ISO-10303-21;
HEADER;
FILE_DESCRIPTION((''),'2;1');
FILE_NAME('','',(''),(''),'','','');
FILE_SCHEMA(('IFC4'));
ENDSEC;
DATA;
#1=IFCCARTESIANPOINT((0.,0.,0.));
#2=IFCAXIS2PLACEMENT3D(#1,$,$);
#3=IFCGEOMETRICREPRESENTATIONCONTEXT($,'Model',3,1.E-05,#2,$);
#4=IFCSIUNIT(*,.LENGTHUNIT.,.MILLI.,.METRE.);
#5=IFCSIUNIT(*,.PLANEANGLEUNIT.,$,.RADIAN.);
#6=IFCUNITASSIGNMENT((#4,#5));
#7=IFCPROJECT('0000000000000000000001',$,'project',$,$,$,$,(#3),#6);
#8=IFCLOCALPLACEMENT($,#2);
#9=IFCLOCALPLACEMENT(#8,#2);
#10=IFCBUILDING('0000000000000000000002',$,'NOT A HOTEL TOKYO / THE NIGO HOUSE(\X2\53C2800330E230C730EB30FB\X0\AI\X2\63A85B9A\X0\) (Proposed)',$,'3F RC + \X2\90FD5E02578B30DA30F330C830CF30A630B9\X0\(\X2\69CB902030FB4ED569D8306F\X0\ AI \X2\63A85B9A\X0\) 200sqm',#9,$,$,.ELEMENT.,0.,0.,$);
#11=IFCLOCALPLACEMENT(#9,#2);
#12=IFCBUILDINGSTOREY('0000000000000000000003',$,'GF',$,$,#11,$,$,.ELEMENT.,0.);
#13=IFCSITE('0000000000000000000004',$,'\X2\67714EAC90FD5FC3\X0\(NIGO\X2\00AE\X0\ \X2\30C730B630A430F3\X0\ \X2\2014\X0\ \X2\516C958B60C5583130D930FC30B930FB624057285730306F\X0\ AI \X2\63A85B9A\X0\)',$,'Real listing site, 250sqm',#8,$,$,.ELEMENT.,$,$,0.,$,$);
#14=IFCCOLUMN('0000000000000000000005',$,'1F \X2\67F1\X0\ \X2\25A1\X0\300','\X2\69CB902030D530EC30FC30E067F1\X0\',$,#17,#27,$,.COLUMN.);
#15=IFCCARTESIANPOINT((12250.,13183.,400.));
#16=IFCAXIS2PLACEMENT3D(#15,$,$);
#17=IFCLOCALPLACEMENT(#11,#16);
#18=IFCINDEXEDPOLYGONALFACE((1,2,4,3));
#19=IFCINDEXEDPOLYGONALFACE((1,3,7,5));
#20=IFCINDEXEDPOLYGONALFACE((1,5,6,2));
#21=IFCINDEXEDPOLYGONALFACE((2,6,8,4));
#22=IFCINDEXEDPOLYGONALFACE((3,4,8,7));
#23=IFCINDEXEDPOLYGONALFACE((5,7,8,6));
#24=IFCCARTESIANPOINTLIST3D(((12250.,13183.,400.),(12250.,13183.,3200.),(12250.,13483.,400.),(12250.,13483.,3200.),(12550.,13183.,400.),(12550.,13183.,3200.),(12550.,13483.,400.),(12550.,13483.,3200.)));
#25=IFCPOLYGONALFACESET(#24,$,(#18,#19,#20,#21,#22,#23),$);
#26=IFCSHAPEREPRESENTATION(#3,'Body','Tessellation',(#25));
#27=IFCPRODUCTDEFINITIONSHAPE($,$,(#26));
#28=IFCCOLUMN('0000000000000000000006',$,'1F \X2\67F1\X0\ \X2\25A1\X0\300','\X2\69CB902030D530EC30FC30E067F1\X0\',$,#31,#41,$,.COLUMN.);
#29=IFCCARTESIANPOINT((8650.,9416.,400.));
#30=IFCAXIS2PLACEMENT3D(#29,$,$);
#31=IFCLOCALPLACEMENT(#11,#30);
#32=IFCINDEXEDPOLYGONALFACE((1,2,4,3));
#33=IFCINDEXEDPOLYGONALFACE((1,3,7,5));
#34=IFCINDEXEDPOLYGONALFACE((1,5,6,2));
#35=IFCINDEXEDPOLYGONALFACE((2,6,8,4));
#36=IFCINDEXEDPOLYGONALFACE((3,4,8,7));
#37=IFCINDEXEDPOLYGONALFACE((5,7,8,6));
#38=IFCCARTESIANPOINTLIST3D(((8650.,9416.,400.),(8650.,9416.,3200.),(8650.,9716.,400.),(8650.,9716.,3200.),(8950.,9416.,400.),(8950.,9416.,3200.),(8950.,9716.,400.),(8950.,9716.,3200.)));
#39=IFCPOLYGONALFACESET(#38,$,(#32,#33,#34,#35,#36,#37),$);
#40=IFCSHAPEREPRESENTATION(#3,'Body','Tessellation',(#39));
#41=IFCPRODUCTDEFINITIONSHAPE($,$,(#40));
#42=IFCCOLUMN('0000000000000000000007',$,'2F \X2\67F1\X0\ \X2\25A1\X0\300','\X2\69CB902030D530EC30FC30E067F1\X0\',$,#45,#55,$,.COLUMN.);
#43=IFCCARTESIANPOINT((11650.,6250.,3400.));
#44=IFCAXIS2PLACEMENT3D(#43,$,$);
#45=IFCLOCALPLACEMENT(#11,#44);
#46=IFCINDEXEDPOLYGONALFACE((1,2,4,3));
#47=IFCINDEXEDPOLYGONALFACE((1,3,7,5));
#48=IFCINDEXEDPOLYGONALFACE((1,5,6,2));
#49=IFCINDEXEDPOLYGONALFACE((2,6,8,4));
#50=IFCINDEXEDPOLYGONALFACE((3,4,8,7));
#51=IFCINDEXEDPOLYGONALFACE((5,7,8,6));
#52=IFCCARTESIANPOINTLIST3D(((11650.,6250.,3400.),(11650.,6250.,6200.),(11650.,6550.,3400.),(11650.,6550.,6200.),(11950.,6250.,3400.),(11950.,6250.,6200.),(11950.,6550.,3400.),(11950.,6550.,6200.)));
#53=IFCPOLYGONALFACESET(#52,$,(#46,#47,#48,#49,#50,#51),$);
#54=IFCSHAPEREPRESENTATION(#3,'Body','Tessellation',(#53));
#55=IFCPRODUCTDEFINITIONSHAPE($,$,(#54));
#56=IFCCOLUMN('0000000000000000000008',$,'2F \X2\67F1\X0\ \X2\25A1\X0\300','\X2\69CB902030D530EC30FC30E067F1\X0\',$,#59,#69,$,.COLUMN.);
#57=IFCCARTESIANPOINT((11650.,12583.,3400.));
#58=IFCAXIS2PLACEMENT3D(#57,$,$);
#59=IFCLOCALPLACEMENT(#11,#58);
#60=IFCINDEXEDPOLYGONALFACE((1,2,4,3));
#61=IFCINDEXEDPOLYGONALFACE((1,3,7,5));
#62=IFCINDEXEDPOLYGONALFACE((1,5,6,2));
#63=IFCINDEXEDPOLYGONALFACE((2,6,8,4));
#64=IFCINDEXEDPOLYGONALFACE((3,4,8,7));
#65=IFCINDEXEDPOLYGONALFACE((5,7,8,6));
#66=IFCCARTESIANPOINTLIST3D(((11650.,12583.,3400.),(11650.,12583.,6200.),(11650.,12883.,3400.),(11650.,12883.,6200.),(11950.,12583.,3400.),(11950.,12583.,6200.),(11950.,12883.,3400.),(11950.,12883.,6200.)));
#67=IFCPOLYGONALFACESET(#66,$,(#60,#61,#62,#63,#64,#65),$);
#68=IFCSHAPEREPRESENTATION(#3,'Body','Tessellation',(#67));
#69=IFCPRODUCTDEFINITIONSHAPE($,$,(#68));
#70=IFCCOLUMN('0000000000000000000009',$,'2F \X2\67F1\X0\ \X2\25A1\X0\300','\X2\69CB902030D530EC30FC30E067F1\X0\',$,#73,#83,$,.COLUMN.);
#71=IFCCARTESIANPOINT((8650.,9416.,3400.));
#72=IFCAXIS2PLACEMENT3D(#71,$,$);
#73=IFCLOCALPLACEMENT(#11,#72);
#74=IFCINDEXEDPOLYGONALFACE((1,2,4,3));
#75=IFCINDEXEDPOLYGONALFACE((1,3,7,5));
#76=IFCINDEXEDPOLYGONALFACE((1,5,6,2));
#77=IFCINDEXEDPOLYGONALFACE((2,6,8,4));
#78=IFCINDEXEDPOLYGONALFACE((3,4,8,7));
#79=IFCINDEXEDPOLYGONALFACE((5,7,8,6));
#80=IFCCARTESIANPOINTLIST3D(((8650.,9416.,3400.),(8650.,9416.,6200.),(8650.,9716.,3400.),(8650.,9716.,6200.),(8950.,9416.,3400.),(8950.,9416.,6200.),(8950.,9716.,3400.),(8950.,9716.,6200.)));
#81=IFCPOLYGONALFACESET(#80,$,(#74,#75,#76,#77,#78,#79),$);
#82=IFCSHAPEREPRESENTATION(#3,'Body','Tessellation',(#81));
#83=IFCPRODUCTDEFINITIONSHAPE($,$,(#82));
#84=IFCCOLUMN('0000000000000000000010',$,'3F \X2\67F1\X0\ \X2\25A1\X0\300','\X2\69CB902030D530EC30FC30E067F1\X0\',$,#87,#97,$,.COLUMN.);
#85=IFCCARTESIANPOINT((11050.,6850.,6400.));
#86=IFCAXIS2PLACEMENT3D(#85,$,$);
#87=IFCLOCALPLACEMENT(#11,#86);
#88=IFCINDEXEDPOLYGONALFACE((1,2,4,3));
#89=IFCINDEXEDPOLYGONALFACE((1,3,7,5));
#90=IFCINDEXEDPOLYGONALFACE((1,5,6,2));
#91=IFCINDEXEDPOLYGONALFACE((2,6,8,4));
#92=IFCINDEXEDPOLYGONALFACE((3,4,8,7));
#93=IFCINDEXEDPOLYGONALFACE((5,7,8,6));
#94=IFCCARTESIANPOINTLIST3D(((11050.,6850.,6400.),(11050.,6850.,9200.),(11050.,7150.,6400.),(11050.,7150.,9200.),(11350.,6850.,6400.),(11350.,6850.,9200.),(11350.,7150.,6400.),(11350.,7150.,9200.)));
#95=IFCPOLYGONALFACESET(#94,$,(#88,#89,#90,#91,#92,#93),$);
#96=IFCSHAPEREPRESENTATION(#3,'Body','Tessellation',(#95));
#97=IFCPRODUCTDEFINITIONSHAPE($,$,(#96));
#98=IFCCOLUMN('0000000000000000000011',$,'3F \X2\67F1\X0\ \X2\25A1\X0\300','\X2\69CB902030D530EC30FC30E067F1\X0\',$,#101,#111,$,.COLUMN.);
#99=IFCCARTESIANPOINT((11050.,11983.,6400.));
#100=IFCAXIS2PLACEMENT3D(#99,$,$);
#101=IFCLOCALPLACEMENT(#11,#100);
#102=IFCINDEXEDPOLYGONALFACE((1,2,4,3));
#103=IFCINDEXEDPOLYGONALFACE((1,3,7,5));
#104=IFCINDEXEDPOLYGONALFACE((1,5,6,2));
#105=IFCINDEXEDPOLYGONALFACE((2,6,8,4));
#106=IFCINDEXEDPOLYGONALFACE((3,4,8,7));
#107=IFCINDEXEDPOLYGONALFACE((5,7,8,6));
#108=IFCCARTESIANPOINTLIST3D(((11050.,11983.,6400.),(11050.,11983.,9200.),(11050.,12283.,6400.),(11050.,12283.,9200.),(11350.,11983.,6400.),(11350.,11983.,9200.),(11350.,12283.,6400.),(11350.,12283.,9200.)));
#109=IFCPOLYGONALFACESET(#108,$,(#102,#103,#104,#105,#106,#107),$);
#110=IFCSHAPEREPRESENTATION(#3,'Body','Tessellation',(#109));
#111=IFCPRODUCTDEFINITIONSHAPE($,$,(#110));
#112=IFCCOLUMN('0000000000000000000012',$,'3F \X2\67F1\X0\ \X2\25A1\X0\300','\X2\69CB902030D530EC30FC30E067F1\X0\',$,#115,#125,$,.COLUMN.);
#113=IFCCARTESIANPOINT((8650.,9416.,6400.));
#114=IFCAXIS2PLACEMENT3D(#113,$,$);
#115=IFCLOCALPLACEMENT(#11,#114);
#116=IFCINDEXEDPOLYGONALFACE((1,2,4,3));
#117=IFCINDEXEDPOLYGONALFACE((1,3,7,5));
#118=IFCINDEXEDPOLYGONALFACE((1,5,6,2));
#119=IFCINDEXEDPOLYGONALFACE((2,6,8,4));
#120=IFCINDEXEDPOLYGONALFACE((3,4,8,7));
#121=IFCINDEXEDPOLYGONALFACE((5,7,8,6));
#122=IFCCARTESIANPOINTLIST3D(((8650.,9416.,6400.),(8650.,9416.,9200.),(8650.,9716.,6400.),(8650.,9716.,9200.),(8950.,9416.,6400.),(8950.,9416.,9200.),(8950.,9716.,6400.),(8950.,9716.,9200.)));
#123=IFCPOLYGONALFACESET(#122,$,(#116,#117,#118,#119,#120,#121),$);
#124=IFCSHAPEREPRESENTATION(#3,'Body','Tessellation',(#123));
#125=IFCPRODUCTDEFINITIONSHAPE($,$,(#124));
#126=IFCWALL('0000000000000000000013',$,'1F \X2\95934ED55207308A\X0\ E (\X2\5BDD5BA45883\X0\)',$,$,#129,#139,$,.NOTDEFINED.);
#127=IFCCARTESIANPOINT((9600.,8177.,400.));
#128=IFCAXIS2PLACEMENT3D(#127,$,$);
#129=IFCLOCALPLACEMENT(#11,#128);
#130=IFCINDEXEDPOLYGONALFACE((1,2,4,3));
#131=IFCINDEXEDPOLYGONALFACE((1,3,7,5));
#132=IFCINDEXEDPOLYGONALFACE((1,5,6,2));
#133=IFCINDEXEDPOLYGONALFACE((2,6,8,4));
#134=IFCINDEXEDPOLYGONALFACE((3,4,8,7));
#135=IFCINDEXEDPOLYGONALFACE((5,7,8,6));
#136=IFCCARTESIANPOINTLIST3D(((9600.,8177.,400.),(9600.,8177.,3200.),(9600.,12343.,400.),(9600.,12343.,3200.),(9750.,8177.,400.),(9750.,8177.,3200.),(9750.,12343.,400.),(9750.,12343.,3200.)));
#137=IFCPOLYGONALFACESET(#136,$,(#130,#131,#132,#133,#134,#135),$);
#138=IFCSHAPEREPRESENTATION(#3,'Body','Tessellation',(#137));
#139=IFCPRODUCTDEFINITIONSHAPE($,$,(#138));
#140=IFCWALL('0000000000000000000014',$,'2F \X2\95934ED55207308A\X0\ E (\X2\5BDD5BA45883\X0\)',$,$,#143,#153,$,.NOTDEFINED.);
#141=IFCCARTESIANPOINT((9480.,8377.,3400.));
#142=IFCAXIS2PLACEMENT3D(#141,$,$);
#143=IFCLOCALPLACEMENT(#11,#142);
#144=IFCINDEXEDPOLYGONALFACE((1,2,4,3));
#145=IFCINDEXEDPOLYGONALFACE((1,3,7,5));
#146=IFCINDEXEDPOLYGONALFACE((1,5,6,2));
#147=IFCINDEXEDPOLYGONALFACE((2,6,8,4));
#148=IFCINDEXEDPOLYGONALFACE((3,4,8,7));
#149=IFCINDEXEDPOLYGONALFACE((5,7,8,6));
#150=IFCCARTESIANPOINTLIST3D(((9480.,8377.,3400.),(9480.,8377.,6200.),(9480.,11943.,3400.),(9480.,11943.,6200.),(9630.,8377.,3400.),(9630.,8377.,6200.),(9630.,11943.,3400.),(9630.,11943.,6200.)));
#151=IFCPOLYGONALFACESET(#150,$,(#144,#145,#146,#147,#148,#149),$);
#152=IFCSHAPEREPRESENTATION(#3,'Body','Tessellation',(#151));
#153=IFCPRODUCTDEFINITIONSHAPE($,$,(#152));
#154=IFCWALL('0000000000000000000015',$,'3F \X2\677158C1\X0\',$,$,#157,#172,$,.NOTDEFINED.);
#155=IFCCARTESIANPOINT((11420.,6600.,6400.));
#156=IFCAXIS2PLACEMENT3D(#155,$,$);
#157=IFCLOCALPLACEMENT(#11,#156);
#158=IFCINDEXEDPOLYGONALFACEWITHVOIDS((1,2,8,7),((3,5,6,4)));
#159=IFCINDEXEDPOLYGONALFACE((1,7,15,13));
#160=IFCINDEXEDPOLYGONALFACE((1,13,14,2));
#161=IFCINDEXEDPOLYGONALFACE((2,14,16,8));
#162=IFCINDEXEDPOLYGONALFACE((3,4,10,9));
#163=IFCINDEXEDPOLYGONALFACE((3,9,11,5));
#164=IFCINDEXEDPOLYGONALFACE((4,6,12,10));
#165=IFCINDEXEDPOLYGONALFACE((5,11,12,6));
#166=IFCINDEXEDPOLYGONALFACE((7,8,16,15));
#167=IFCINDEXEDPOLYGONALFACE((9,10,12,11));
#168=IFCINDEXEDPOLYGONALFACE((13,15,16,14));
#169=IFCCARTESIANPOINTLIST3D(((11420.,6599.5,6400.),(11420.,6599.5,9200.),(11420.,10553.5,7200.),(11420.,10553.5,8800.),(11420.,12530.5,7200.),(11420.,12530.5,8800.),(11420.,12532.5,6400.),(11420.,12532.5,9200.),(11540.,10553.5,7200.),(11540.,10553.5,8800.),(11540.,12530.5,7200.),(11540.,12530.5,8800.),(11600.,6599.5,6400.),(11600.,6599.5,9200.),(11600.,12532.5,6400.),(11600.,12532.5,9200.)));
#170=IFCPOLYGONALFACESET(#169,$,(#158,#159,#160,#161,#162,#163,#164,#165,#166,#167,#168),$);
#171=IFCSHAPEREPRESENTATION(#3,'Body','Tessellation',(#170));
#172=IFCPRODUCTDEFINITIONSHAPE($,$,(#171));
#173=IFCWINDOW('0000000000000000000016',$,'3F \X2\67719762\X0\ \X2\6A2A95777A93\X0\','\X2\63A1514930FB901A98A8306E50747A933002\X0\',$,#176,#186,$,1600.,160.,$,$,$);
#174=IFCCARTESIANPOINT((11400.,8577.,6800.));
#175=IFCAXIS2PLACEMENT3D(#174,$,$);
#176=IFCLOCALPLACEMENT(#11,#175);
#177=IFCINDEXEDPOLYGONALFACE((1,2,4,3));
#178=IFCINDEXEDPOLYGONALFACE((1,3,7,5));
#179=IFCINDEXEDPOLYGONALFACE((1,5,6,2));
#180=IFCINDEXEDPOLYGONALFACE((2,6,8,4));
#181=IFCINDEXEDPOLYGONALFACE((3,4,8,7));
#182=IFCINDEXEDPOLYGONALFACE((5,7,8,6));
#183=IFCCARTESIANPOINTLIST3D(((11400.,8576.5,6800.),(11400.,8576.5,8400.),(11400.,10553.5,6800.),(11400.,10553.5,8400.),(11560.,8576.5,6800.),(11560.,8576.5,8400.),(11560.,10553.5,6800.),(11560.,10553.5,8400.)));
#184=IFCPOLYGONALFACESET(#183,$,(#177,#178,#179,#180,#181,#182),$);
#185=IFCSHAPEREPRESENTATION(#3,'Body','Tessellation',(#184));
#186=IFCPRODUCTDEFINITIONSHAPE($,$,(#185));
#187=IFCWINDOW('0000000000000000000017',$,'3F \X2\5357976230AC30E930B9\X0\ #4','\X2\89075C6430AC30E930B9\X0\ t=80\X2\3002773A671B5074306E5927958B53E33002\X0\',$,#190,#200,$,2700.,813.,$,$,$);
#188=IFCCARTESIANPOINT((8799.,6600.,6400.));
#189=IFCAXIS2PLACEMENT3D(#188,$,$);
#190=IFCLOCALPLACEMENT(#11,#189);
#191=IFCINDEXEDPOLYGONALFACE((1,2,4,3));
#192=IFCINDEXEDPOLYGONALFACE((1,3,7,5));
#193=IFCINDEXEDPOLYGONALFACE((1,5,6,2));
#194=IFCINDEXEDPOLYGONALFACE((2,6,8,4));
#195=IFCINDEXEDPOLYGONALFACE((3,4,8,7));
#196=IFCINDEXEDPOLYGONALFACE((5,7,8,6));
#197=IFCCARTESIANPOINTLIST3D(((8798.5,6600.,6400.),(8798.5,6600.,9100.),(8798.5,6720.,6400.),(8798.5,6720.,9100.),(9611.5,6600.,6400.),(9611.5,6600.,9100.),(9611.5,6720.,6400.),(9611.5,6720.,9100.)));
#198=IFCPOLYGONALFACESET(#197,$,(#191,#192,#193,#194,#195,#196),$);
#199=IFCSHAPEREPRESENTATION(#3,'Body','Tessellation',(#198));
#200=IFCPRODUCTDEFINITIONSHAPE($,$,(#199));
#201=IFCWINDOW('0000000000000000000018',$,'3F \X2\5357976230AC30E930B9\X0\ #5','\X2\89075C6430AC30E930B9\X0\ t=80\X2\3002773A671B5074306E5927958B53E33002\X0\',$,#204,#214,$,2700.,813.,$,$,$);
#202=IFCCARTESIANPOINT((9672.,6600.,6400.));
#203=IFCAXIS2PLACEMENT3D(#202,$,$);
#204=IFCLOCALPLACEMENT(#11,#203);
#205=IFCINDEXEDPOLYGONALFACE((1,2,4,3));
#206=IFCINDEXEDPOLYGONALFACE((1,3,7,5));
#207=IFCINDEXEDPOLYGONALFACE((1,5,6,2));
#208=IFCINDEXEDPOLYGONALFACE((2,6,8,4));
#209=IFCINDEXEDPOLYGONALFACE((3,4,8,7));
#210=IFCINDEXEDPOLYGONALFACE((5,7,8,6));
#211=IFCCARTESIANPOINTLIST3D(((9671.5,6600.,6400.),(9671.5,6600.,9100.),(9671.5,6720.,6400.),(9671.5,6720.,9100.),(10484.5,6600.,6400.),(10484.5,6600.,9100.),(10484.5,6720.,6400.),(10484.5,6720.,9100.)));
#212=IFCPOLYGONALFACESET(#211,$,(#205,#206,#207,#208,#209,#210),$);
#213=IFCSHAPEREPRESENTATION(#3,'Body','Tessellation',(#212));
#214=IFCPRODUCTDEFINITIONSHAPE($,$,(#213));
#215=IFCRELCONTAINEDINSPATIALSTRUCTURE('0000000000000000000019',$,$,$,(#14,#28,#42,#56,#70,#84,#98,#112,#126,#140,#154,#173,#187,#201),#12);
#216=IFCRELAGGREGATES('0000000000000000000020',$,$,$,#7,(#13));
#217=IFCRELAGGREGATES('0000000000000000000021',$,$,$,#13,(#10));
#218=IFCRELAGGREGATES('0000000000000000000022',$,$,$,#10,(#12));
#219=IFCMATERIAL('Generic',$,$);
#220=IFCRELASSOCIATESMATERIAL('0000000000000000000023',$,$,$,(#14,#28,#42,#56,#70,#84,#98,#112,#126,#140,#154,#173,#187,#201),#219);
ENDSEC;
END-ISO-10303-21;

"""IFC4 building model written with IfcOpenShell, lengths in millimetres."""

from ifc_helpers import new_model, si_unit, frame, frame_2d, origin, place, context, project, spatial, rectangle, extrude, material, element, fill, save


model = new_model("IFC4")

# Units and contexts
model_context = context("Model", 3, precision=1e-05, world=origin())
ifc_project = project(units=[si_unit("LENGTHUNIT", "METRE", prefix="MILLI"), si_unit("PLANEANGLEUNIT", "RADIAN")], contexts=[model_context])

# Site, building, storey
site_placement = place(None, origin())
site = spatial("IfcSite", under=ifc_project, at=site_placement, Name="東京都心(NIGO® デザイン — 公開情報ベース・所在地は AI 推定)", ObjectType="Real listing site, 250sqm", CompositionType="ELEMENT", RefElevation=0.0)
building_placement = place(site_placement, origin())
building = spatial("IfcBuilding", under=site, at=building_placement, Name="NOT A HOTEL TOKYO / THE NIGO HOUSE(参考モデル・AI推定) (Proposed)", ObjectType="3F RC + 都市型ペントハウス(構造・仕様は AI 推定) 200sqm", CompositionType="ELEMENT", ElevationOfRefHeight=0.0, ElevationOfTerrain=0.0)
storey_placement = place(building_placement, origin())
storey = spatial("IfcBuildingStorey", under=building, at=storey_placement, Name="GF", CompositionType="ELEMENT", Elevation=0.0)

# Columns
ifc_material_1 = material(Name="Generic")
column_1_placement = place(storey_placement, frame((12250.0, 13183.0, 400.0)))
element("IfcColumn", 1, at=column_1_placement, inside=storey, material=ifc_material_1, Name="1F 柱 □300", Description="構造フレーム柱", PredefinedType="COLUMN", context=model_context, shape_type="SweptSolid", body=[
    extrude(rectangle(XDim=300.0, YDim=300.0, at=frame_2d((150.0, 150.0))), frame((12250.0, 13183.0, 400.0)), (0.0, 0.0, 1.0), 2800.0),
])
column_2_placement = place(storey_placement, frame((8650.0, 9416.0, 400.0)))
element("IfcColumn", 2, at=column_2_placement, inside=storey, material=ifc_material_1, Name="1F 柱 □300", Description="構造フレーム柱", PredefinedType="COLUMN", context=model_context, shape_type="SweptSolid", body=[
    extrude(rectangle(XDim=300.0, YDim=300.0, at=frame_2d((150.0, 150.0))), frame((8650.0, 9416.0, 400.0)), (0.0, 0.0, 1.0), 2800.0),
])
column_3_placement = place(storey_placement, frame((11650.0, 6250.0, 3400.0)))
element("IfcColumn", 3, at=column_3_placement, inside=storey, material=ifc_material_1, Name="2F 柱 □300", Description="構造フレーム柱", PredefinedType="COLUMN", context=model_context, shape_type="SweptSolid", body=[
    extrude(rectangle(XDim=300.0, YDim=300.0, at=frame_2d((150.0, 150.0))), frame((11650.0, 6250.0, 3400.0)), (0.0, 0.0, 1.0), 2800.0),
])
column_4_placement = place(storey_placement, frame((11650.0, 12583.0, 3400.0)))
element("IfcColumn", 4, at=column_4_placement, inside=storey, material=ifc_material_1, Name="2F 柱 □300", Description="構造フレーム柱", PredefinedType="COLUMN", context=model_context, shape_type="SweptSolid", body=[
    extrude(rectangle(XDim=300.0, YDim=300.0, at=frame_2d((150.0, 150.0))), frame((11650.0, 12583.0, 3400.0)), (0.0, 0.0, 1.0), 2800.0),
])
column_5_placement = place(storey_placement, frame((8650.0, 9416.0, 3400.0)))
element("IfcColumn", 5, at=column_5_placement, inside=storey, material=ifc_material_1, Name="2F 柱 □300", Description="構造フレーム柱", PredefinedType="COLUMN", context=model_context, shape_type="SweptSolid", body=[
    extrude(rectangle(XDim=300.0, YDim=300.0, at=frame_2d((150.0, 150.0))), frame((8650.0, 9416.0, 3400.0)), (0.0, 0.0, 1.0), 2800.0),
])
column_6_placement = place(storey_placement, frame((11050.0, 6850.0, 6400.0)))
element("IfcColumn", 6, at=column_6_placement, inside=storey, material=ifc_material_1, Name="3F 柱 □300", Description="構造フレーム柱", PredefinedType="COLUMN", context=model_context, shape_type="SweptSolid", body=[
    extrude(rectangle(XDim=300.0, YDim=300.0, at=frame_2d((150.0, 150.0))), frame((11050.0, 6850.0, 6400.0)), (0.0, 0.0, 1.0), 2800.0),
])
column_7_placement = place(storey_placement, frame((11050.0, 11983.0, 6400.0)))
element("IfcColumn", 7, at=column_7_placement, inside=storey, material=ifc_material_1, Name="3F 柱 □300", Description="構造フレーム柱", PredefinedType="COLUMN", context=model_context, shape_type="SweptSolid", body=[
    extrude(rectangle(XDim=300.0, YDim=300.0, at=frame_2d((150.0, 150.0))), frame((11050.0, 11983.0, 6400.0)), (0.0, 0.0, 1.0), 2800.0),
])
column_8_placement = place(storey_placement, frame((8650.0, 9416.0, 6400.0)))
element("IfcColumn", 8, at=column_8_placement, inside=storey, material=ifc_material_1, Name="3F 柱 □300", Description="構造フレーム柱", PredefinedType="COLUMN", context=model_context, shape_type="SweptSolid", body=[
    extrude(rectangle(XDim=300.0, YDim=300.0, at=frame_2d((150.0, 150.0))), frame((8650.0, 9416.0, 6400.0)), (0.0, 0.0, 1.0), 2800.0),
])

# Walls
wall_1_placement = place(storey_placement, frame((9600.0, 8177.0, 400.0)))
element("IfcWall", 9, at=wall_1_placement, inside=storey, material=ifc_material_1, Name="1F 間仕切り E (寝室境)", PredefinedType="NOTDEFINED", context=model_context, shape_type="SweptSolid", body=[
    extrude(rectangle(XDim=150.0, YDim=4166.0, at=frame_2d((75.0, 2083.0))), frame((9600.0, 8177.0, 400.0)), (0.0, 0.0, 1.0), 2800.0),
])
wall_2_placement = place(storey_placement, frame((9480.0, 8377.0, 3400.0)))
element("IfcWall", 10, at=wall_2_placement, inside=storey, material=ifc_material_1, Name="2F 間仕切り E (寝室境)", PredefinedType="NOTDEFINED", context=model_context, shape_type="SweptSolid", body=[
    extrude(rectangle(XDim=150.0, YDim=3566.0, at=frame_2d((75.0, 1783.0))), frame((9480.0, 8377.0, 3400.0)), (0.0, 0.0, 1.0), 2800.0),
])

# Wall, opening, window
wall_3_placement = place(storey_placement, frame((11420.0, 6600.0, 6400.0)))
wall_3 = element("IfcWall", 11, at=wall_3_placement, inside=storey, material=ifc_material_1, Name="3F 東壁", PredefinedType="NOTDEFINED", context=model_context, shape_type="SweptSolid", body=[
    extrude(rectangle(XDim=180.0, YDim=5933.0, at=frame_2d((90.0, 2966.0))), frame((11420.0, 6600.0, 6400.0)), (0.0, 0.0, 1.0), 2800.0),
])
opening_placement = place(storey_placement, frame((11400.0, 8577.0, 6800.0)))
opening = element("IfcOpeningElement", 12, at=opening_placement, cuts=wall_3, PredefinedType="NOTDEFINED", context=model_context, shape_type="SweptSolid", body=[
    extrude(rectangle(XDim=160.0, YDim=1977.0, at=frame_2d((80.0, 988.0))), frame((11400.0, 8577.0, 6800.0)), (0.0, 0.0, 1.0), 1600.0),
])
window_1_placement = place(storey_placement, frame((11400.0, 8577.0, 6800.0)))
window_1 = element("IfcWindow", 13, at=window_1_placement, inside=storey, material=ifc_material_1, Name="3F 東面 横長窓", Description="採光・通風の側窓。", OverallHeight=1600.0, OverallWidth=160.0, context=model_context, shape_type="SweptSolid", body=[
    extrude(rectangle(XDim=160.0, YDim=1977.0, at=frame_2d((80.0, 988.0))), frame((11400.0, 8577.0, 6800.0)), (0.0, 0.0, 1.0), 1600.0),
])
fill(opening, window_1)

# Windows
window_2_placement = place(storey_placement, frame((8799.0, 6600.0, 6400.0)))
element("IfcWindow", 14, at=window_2_placement, inside=storey, material=ifc_material_1, Name="3F 南面ガラス #4", Description="複層ガラス t=80。眺望側の大開口。", OverallHeight=2700.0, OverallWidth=813.0, context=model_context, shape_type="SweptSolid", body=[
    extrude(rectangle(XDim=813.0, YDim=120.0, at=frame_2d((406.0, 60.0))), frame((8799.0, 6600.0, 6400.0)), (0.0, 0.0, 1.0), 2700.0),
])
window_3_placement = place(storey_placement, frame((9672.0, 6600.0, 6400.0)))
element("IfcWindow", 15, at=window_3_placement, inside=storey, material=ifc_material_1, Name="3F 南面ガラス #5", Description="複層ガラス t=80。眺望側の大開口。", OverallHeight=2700.0, OverallWidth=813.0, context=model_context, shape_type="SweptSolid", body=[
    extrude(rectangle(XDim=813.0, YDim=120.0, at=frame_2d((406.0, 60.0))), frame((9672.0, 6600.0, 6400.0)), (0.0, 0.0, 1.0), 2700.0),
])

save(model, "model.ifc")
